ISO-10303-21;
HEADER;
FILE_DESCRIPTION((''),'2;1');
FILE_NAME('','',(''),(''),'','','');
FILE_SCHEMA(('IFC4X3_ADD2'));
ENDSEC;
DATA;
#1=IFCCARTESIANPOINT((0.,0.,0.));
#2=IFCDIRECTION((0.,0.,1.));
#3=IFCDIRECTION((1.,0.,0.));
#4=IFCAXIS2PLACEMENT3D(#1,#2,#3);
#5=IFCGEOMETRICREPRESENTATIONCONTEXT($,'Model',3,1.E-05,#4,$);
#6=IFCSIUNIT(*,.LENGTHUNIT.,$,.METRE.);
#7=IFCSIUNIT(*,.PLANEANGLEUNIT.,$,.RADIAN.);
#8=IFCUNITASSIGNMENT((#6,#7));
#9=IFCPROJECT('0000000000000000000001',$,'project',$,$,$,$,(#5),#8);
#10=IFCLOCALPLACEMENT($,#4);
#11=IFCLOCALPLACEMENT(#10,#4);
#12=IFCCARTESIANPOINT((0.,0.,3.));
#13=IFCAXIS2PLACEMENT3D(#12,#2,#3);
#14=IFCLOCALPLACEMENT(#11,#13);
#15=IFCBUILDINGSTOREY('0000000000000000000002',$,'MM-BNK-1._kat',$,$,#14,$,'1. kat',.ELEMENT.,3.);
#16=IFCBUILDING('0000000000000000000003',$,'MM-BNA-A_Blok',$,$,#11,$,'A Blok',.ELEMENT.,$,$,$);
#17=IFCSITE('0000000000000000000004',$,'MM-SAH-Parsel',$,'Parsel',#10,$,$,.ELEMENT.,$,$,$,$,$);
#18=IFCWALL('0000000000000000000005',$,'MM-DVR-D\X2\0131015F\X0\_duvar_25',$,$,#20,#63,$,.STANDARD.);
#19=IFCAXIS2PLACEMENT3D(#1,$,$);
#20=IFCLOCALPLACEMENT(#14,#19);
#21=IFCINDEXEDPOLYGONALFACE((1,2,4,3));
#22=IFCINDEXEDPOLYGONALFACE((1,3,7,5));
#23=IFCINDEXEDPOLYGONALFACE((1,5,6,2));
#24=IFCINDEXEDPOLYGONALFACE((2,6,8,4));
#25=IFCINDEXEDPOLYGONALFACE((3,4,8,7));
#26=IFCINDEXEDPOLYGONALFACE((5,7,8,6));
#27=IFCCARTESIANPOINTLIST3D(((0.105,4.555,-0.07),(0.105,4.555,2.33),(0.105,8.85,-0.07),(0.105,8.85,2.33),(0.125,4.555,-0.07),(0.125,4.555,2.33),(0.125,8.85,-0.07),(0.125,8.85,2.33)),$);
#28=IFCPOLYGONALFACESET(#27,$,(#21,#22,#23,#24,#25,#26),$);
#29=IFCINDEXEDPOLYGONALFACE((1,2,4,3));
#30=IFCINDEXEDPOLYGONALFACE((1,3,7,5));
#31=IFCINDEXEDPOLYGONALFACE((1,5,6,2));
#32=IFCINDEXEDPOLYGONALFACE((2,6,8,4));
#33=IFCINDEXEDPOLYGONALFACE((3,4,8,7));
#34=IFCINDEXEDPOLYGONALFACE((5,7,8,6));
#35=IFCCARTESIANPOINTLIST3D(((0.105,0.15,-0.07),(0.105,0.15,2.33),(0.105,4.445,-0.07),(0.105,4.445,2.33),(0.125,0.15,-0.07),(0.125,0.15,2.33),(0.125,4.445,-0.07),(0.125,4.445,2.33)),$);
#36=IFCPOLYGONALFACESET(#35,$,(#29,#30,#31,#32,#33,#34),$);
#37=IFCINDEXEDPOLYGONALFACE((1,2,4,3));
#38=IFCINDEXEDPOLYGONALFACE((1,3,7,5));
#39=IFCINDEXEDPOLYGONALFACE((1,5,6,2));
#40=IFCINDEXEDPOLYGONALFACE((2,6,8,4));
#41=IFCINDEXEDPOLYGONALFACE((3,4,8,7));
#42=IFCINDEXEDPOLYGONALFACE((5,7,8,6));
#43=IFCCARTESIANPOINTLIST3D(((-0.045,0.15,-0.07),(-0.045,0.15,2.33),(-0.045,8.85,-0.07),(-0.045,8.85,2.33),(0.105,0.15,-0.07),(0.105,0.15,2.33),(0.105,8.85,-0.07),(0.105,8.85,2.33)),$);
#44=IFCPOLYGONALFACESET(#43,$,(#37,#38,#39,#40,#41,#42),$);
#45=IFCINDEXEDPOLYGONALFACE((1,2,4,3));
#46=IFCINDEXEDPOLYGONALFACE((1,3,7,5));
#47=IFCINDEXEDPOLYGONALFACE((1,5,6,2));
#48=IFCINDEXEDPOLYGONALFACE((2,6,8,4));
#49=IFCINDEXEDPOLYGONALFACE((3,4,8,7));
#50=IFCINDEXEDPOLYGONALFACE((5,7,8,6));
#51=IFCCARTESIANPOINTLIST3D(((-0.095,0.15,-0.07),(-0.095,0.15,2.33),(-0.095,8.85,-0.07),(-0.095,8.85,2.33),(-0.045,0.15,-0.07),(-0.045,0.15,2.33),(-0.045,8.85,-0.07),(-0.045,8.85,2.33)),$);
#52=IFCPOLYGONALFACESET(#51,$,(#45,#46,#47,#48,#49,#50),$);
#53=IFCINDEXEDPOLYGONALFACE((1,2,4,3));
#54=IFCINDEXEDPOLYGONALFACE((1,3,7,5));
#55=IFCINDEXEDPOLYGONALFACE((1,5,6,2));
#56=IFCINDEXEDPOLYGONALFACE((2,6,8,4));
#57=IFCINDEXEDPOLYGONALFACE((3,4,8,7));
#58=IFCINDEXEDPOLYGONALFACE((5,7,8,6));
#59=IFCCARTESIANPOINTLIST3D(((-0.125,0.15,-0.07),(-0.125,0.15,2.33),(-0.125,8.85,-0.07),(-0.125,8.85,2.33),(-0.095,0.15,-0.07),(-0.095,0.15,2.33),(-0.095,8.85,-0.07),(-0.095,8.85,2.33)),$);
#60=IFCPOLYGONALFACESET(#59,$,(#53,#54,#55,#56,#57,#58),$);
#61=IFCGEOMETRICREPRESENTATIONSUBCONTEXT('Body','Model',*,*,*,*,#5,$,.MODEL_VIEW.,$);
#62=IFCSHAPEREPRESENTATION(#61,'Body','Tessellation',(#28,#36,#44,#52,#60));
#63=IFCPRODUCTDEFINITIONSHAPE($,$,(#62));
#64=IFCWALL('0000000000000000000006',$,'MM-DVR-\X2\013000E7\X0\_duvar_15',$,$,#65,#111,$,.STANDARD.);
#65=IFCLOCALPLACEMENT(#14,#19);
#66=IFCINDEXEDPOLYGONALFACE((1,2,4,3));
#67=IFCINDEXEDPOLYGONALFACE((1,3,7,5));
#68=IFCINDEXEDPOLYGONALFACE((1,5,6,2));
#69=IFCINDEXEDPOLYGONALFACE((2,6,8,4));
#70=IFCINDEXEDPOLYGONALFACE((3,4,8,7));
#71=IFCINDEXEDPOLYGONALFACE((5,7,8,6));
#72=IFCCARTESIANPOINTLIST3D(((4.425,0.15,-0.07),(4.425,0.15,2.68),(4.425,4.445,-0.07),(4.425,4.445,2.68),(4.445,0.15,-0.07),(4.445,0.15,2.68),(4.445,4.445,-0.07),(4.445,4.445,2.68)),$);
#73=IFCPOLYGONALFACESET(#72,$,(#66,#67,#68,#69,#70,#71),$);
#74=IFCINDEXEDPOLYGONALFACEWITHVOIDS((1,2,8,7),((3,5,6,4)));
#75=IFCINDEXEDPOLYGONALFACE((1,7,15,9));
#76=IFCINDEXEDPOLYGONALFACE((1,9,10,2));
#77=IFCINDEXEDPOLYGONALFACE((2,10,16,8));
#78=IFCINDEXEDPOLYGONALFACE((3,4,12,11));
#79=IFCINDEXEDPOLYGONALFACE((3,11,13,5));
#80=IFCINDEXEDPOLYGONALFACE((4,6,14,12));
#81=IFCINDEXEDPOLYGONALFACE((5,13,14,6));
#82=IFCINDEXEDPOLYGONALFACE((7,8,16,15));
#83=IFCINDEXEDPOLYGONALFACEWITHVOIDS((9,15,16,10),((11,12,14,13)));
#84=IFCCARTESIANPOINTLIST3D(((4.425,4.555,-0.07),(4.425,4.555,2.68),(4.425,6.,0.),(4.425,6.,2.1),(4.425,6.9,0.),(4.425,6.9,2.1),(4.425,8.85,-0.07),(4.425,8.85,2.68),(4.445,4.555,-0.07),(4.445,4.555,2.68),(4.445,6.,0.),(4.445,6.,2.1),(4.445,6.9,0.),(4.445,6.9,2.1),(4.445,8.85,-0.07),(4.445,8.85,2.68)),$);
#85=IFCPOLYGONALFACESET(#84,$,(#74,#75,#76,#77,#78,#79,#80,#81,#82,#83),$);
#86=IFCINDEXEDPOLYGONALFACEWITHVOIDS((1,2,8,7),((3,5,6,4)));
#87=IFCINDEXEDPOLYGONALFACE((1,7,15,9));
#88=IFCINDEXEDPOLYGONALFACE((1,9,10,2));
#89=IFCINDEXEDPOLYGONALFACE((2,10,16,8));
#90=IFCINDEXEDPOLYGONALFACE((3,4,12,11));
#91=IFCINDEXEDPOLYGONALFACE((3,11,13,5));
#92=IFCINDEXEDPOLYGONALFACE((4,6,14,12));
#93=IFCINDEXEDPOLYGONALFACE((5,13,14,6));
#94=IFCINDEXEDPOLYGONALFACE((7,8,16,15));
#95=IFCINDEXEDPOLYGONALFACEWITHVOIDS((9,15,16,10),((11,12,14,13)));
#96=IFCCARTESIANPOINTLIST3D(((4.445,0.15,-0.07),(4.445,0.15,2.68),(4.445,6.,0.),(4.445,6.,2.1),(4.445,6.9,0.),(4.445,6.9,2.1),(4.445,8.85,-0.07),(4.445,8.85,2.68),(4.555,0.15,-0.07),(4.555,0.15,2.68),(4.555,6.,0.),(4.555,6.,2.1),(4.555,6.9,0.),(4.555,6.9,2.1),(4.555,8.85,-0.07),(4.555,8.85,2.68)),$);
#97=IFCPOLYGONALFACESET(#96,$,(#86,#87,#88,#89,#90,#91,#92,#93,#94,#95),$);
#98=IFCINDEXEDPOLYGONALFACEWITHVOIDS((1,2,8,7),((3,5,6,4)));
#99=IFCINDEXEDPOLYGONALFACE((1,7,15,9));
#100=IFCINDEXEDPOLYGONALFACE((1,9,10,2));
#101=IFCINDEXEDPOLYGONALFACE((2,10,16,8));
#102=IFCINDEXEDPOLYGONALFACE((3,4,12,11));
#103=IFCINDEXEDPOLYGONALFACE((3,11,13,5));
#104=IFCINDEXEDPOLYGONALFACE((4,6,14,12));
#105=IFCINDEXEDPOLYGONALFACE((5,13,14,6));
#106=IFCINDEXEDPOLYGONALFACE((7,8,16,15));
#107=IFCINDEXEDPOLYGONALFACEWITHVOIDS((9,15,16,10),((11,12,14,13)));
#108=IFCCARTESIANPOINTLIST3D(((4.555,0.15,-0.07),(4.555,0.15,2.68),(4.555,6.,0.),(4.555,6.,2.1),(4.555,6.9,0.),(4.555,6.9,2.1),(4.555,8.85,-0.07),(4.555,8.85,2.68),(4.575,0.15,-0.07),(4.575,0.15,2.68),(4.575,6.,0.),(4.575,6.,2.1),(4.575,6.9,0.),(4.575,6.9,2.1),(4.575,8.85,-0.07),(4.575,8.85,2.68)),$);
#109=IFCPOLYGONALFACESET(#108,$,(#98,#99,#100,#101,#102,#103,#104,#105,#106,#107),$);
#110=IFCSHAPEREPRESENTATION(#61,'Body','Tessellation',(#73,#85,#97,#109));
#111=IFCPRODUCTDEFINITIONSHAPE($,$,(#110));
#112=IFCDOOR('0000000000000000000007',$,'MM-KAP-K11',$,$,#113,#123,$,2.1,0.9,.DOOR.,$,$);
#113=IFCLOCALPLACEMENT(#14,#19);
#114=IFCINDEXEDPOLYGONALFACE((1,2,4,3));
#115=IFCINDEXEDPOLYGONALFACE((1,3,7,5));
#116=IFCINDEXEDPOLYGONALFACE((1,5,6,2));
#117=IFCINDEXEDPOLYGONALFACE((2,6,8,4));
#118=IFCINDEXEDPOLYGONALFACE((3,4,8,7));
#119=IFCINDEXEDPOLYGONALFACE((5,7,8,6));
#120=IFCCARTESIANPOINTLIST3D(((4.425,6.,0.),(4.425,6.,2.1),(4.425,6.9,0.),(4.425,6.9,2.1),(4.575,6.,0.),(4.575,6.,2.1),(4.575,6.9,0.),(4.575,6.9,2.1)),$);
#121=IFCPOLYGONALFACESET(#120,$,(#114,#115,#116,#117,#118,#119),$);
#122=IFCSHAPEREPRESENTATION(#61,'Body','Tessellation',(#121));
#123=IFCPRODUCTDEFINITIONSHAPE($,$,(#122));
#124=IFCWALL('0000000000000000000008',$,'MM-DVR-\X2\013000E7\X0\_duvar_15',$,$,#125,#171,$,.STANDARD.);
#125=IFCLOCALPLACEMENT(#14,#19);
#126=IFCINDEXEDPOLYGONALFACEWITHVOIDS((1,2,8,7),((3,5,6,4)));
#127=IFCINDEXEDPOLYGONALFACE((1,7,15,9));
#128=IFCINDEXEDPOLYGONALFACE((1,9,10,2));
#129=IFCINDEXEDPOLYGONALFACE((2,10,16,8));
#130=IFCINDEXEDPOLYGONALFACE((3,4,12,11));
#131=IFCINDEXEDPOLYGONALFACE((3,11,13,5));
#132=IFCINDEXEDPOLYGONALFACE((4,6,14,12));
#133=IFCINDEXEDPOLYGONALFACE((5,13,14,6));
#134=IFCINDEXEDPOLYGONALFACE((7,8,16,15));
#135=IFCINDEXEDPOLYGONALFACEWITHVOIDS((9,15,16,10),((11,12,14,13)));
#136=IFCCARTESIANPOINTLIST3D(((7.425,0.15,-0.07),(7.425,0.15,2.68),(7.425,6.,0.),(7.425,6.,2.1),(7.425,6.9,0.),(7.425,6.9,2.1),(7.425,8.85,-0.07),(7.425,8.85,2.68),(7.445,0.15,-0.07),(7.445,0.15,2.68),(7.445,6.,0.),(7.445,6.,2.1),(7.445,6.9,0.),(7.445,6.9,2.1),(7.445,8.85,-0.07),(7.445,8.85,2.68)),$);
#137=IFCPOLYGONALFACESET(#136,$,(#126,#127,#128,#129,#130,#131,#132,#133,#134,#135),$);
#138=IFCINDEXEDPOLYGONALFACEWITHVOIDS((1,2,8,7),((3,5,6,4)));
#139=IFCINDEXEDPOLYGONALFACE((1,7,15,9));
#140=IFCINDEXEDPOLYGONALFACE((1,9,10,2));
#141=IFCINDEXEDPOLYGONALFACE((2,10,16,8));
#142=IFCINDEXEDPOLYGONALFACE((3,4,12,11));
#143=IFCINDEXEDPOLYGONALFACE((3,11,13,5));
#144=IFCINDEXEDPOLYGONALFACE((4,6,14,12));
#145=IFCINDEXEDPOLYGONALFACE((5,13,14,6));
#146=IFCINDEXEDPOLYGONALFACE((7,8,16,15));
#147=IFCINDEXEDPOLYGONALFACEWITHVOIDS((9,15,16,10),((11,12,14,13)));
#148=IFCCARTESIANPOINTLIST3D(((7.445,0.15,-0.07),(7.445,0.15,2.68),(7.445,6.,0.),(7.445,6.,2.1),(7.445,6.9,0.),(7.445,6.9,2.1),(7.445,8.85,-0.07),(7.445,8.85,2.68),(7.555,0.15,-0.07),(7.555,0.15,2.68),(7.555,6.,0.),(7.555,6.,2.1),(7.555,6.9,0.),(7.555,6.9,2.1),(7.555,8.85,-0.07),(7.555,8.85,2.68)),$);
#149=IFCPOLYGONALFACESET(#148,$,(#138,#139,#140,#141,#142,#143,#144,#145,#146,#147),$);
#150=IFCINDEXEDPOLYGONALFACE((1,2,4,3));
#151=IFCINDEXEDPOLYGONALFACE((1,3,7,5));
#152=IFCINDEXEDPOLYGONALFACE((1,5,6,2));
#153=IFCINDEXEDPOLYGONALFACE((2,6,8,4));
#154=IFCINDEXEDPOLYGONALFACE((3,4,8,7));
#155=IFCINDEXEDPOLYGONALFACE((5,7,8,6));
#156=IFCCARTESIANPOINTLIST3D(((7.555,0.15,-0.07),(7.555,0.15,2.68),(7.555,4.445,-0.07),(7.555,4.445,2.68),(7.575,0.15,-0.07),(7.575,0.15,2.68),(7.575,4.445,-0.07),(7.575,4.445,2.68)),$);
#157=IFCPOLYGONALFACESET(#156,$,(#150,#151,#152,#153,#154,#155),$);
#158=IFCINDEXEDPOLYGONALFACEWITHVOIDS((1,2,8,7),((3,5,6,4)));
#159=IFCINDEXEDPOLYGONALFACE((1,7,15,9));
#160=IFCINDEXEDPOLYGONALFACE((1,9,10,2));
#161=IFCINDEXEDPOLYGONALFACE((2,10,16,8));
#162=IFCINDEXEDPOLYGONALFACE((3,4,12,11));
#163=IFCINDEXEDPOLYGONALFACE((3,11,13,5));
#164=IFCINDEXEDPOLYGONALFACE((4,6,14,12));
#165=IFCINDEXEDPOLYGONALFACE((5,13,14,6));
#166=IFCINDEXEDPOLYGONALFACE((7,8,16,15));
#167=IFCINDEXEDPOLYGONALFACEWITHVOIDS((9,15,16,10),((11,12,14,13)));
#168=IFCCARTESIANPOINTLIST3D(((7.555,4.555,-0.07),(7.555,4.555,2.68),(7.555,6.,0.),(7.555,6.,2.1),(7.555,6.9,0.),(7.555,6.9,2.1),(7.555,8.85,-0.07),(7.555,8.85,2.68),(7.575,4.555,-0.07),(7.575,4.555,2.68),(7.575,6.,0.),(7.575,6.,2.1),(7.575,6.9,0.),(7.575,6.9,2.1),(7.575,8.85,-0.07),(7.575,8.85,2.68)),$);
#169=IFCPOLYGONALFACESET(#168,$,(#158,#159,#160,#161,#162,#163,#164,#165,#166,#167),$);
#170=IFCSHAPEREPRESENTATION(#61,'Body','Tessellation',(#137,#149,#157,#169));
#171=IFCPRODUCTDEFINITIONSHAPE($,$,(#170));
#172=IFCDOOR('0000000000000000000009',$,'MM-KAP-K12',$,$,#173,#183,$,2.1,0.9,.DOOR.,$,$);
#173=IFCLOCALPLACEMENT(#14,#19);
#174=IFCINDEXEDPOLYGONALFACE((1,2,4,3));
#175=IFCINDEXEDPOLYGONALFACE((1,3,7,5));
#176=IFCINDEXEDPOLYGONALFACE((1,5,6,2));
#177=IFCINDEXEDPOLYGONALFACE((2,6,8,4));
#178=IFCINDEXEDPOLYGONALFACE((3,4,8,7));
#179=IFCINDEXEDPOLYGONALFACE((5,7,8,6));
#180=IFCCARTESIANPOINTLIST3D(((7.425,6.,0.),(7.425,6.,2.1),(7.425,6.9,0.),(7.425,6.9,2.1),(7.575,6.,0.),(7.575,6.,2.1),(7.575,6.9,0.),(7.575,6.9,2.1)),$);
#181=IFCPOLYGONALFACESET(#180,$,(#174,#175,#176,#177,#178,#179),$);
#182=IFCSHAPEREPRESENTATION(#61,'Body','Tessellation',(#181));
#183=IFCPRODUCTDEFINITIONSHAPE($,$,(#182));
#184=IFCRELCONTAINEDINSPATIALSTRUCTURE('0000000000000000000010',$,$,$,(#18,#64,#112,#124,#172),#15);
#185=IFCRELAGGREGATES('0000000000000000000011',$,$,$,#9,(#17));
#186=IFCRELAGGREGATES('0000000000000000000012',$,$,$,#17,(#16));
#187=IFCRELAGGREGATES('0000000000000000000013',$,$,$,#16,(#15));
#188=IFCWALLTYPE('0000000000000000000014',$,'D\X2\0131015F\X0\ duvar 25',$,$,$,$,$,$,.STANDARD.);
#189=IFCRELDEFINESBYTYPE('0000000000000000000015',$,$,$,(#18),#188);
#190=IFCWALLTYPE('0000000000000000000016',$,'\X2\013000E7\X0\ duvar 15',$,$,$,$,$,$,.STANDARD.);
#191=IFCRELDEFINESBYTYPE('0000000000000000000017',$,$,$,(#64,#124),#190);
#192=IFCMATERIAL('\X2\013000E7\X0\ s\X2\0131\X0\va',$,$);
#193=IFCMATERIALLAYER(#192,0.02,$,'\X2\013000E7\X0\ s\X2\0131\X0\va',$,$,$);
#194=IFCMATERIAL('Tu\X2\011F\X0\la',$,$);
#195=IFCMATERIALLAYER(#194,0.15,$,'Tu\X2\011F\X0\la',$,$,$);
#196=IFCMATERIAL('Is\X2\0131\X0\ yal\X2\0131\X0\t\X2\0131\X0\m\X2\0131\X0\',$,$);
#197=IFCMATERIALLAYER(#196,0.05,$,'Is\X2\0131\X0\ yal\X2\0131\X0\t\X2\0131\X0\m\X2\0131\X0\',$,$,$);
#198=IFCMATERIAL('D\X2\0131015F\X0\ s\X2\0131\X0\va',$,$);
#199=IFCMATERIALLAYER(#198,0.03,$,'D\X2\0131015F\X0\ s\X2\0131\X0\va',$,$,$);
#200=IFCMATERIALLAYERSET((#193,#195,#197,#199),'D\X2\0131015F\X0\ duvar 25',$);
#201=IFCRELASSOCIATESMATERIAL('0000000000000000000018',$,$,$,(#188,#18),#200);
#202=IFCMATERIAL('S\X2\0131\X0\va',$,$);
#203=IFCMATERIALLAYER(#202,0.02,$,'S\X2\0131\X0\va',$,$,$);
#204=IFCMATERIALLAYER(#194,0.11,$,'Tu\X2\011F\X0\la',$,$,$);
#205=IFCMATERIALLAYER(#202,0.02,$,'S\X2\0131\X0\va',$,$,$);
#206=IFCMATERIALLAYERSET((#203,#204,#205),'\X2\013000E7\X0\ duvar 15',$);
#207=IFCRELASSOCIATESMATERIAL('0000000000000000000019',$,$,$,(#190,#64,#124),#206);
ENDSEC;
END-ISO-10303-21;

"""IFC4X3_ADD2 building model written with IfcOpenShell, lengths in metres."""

from ifc_helpers import new_model, si_unit, frame, origin, origin_with_axes, place, context, subcontext, project, spatial, polyline, outline, extrude, material, layer, layer_set, type_object, element, fill, save


model = new_model("IFC4X3_ADD2")

# Units and contexts
model_context = context("Model", 3, precision=1e-05, world=origin_with_axes())
body_context = subcontext(model_context, "Body", "Model", "MODEL_VIEW")
ifc_project = project(units=[si_unit("LENGTHUNIT", "METRE"), si_unit("PLANEANGLEUNIT", "RADIAN")], contexts=[model_context])

# Site, building, storey
site_placement = place(None, origin_with_axes())
site = spatial("IfcSite", under=ifc_project, at=site_placement, Name="MM-SAH-Parsel", ObjectType="Parsel", CompositionType="ELEMENT")
building_placement = place(site_placement, origin_with_axes())
building = spatial("IfcBuilding", under=site, at=building_placement, Name="MM-BNA-A_Blok", LongName="A Blok", CompositionType="ELEMENT")
storey_placement = place(building_placement, frame((0.0, 0.0, 3.0), z_axis=(0.0, 0.0, 1.0), x_axis=(1.0, 0.0, 0.0)))
storey = spatial("IfcBuildingStorey", under=building, at=storey_placement, Name="MM-BNK-1._kat", LongName="1. kat", CompositionType="ELEMENT", Elevation=3.0)

# Shared definitions
ifc_material_1 = material(Name="İç sıva")
ifc_layer_1 = layer(ifc_material_1, 0.02, Name="İç sıva")
ifc_material_2 = material(Name="Tuğla")
ifc_layer_2 = layer(ifc_material_2, 0.15, Name="Tuğla")
ifc_material_3 = material(Name="Isı yalıtımı")
ifc_layer_3 = layer(ifc_material_3, 0.05, Name="Isı yalıtımı")
ifc_material_4 = material(Name="Dış sıva")
ifc_layer_4 = layer(ifc_material_4, 0.03, Name="Dış sıva")
ifc_layer_set_1 = layer_set([ifc_layer_1, ifc_layer_2, ifc_layer_3, ifc_layer_4], Name="Dış duvar 25")
wall_type_1 = type_object("IfcWallType", Name="Dış duvar 25", PredefinedType="STANDARD", material=ifc_layer_set_1)

# Wall
wall_1_placement = place(storey_placement, origin_with_axes())
element("IfcWall", 1, at=wall_1_placement, inside=storey, type_object=wall_type_1, material=ifc_layer_set_1, Name="MM-DVR-Dış_duvar_25", PredefinedType="STANDARD", context=body_context, shape_type="SweptSolid", body=[
    extrude(outline(polyline([(0.105, 8.85), (0.105, 4.555), (0.125, 4.555), (0.125, 8.85), (0.105, 8.85)])), frame((0.0, 0.0, -0.07)), (0.0, 0.0, 1.0), 2.4),
    extrude(outline(polyline([(0.105, 4.445), (0.105, 0.15), (0.125, 0.15), (0.125, 4.445), (0.105, 4.445)])), frame((0.0, 0.0, -0.07)), (0.0, 0.0, 1.0), 2.4),
    extrude(outline(polyline([(-0.045, 8.85), (-0.045, 0.15), (0.105, 0.15), (0.105, 8.85), (-0.045, 8.85)])), frame((0.0, 0.0, -0.07)), (0.0, 0.0, 1.0), 2.4),
    extrude(outline(polyline([(-0.095, 8.85), (-0.095, 0.15), (-0.045, 0.15), (-0.045, 8.85), (-0.095, 8.85)])), frame((0.0, 0.0, -0.07)), (0.0, 0.0, 1.0), 2.4),
    extrude(outline(polyline([(-0.125, 8.85), (-0.125, 0.15), (-0.095, 0.15), (-0.095, 8.85), (-0.125, 8.85)])), frame((0.0, 0.0, -0.07)), (0.0, 0.0, 1.0), 2.4),
])

# Walls, openings, doors
ifc_material_5 = material(Name="Sıva")
ifc_layer_5 = layer(ifc_material_5, 0.02, Name="Sıva")
ifc_layer_6 = layer(ifc_material_2, 0.11, Name="Tuğla")
ifc_layer_7 = layer(ifc_material_5, 0.02, Name="Sıva")
ifc_layer_set_2 = layer_set([ifc_layer_5, ifc_layer_6, ifc_layer_7], Name="İç duvar 15")
wall_type_2 = type_object("IfcWallType", Name="İç duvar 15", PredefinedType="STANDARD", material=ifc_layer_set_2)
wall_2_placement = place(storey_placement, origin_with_axes())
wall_2 = element("IfcWall", 2, at=wall_2_placement, inside=storey, type_object=wall_type_2, material=ifc_layer_set_2, Name="MM-DVR-İç_duvar_15", PredefinedType="STANDARD", context=body_context, shape_type="SweptSolid", body=[
    extrude(outline(polyline([(4.445, 0.15), (4.445, 4.445), (4.425, 4.445), (4.425, 0.15), (4.445, 0.15)])), frame((0.0, 0.0, -0.07)), (0.0, 0.0, 1.0), 2.75),
    extrude(outline(polyline([(4.445, 4.555), (4.445, 8.85), (4.425, 8.85), (4.425, 4.555), (4.445, 4.555)])), frame((0.0, 0.0, -0.07)), (0.0, 0.0, 1.0), 2.75),
    extrude(outline(polyline([(4.555, 0.15), (4.555, 8.85), (4.445, 8.85), (4.445, 0.15), (4.555, 0.15)])), frame((0.0, 0.0, -0.07)), (0.0, 0.0, 1.0), 2.75),
    extrude(outline(polyline([(4.575, 0.15), (4.575, 8.85), (4.555, 8.85), (4.555, 0.15), (4.575, 0.15)])), frame((0.0, 0.0, -0.07)), (0.0, 0.0, 1.0), 2.75),
])
opening_1_placement = place(storey_placement, origin_with_axes())
opening_1 = element("IfcOpeningElement", 3, at=opening_1_placement, cuts=wall_2, PredefinedType="OPENING", context=body_context, shape_type="SweptSolid", body=[
    extrude(outline(polyline([(4.425, 6.0), (4.425, 6.9), (4.575, 6.9), (4.575, 6.0), (4.425, 6.0)])), origin(), (0.0, 0.0, 1.0), 2.1),
])
door_1_placement = place(storey_placement, origin_with_axes())
door_1 = element("IfcDoor", 4, at=door_1_placement, inside=storey, Name="MM-KAP-K11", OverallHeight=2.1, OverallWidth=0.9, PredefinedType="DOOR", context=body_context, shape_type="SweptSolid", body=[
    extrude(outline(polyline([(4.425, 6.0), (4.425, 6.9), (4.575, 6.9), (4.575, 6.0), (4.425, 6.0)])), origin(), (0.0, 0.0, 1.0), 2.1),
])
fill(opening_1, door_1)
wall_3_placement = place(storey_placement, origin_with_axes())
wall_3 = element("IfcWall", 5, at=wall_3_placement, inside=storey, type_object=wall_type_2, material=ifc_layer_set_2, Name="MM-DVR-İç_duvar_15", PredefinedType="STANDARD", context=body_context, shape_type="SweptSolid", body=[
    extrude(outline(polyline([(7.445, 0.15), (7.445, 8.85), (7.425, 8.85), (7.425, 0.15), (7.445, 0.15)])), frame((0.0, 0.0, -0.07)), (0.0, 0.0, 1.0), 2.75),
    extrude(outline(polyline([(7.555, 0.15), (7.555, 8.85), (7.445, 8.85), (7.445, 0.15), (7.555, 0.15)])), frame((0.0, 0.0, -0.07)), (0.0, 0.0, 1.0), 2.75),
    extrude(outline(polyline([(7.575, 0.15), (7.575, 4.445), (7.555, 4.445), (7.555, 0.15), (7.575, 0.15)])), frame((0.0, 0.0, -0.07)), (0.0, 0.0, 1.0), 2.75),
    extrude(outline(polyline([(7.575, 4.555), (7.575, 8.85), (7.555, 8.85), (7.555, 4.555), (7.575, 4.555)])), frame((0.0, 0.0, -0.07)), (0.0, 0.0, 1.0), 2.75),
])
opening_2_placement = place(storey_placement, origin_with_axes())
opening_2 = element("IfcOpeningElement", 6, at=opening_2_placement, cuts=wall_3, PredefinedType="OPENING", context=body_context, shape_type="SweptSolid", body=[
    extrude(outline(polyline([(7.425, 6.0), (7.425, 6.9), (7.575, 6.9), (7.575, 6.0), (7.425, 6.0)])), origin(), (0.0, 0.0, 1.0), 2.1),
])
door_2_placement = place(storey_placement, origin_with_axes())
door_2 = element("IfcDoor", 7, at=door_2_placement, inside=storey, Name="MM-KAP-K12", OverallHeight=2.1, OverallWidth=0.9, PredefinedType="DOOR", context=body_context, shape_type="SweptSolid", body=[
    extrude(outline(polyline([(7.425, 6.0), (7.425, 6.9), (7.575, 6.9), (7.575, 6.0), (7.425, 6.0)])), origin(), (0.0, 0.0, 1.0), 2.1),
])
fill(opening_2, door_2)

save(model, "model.ifc")
